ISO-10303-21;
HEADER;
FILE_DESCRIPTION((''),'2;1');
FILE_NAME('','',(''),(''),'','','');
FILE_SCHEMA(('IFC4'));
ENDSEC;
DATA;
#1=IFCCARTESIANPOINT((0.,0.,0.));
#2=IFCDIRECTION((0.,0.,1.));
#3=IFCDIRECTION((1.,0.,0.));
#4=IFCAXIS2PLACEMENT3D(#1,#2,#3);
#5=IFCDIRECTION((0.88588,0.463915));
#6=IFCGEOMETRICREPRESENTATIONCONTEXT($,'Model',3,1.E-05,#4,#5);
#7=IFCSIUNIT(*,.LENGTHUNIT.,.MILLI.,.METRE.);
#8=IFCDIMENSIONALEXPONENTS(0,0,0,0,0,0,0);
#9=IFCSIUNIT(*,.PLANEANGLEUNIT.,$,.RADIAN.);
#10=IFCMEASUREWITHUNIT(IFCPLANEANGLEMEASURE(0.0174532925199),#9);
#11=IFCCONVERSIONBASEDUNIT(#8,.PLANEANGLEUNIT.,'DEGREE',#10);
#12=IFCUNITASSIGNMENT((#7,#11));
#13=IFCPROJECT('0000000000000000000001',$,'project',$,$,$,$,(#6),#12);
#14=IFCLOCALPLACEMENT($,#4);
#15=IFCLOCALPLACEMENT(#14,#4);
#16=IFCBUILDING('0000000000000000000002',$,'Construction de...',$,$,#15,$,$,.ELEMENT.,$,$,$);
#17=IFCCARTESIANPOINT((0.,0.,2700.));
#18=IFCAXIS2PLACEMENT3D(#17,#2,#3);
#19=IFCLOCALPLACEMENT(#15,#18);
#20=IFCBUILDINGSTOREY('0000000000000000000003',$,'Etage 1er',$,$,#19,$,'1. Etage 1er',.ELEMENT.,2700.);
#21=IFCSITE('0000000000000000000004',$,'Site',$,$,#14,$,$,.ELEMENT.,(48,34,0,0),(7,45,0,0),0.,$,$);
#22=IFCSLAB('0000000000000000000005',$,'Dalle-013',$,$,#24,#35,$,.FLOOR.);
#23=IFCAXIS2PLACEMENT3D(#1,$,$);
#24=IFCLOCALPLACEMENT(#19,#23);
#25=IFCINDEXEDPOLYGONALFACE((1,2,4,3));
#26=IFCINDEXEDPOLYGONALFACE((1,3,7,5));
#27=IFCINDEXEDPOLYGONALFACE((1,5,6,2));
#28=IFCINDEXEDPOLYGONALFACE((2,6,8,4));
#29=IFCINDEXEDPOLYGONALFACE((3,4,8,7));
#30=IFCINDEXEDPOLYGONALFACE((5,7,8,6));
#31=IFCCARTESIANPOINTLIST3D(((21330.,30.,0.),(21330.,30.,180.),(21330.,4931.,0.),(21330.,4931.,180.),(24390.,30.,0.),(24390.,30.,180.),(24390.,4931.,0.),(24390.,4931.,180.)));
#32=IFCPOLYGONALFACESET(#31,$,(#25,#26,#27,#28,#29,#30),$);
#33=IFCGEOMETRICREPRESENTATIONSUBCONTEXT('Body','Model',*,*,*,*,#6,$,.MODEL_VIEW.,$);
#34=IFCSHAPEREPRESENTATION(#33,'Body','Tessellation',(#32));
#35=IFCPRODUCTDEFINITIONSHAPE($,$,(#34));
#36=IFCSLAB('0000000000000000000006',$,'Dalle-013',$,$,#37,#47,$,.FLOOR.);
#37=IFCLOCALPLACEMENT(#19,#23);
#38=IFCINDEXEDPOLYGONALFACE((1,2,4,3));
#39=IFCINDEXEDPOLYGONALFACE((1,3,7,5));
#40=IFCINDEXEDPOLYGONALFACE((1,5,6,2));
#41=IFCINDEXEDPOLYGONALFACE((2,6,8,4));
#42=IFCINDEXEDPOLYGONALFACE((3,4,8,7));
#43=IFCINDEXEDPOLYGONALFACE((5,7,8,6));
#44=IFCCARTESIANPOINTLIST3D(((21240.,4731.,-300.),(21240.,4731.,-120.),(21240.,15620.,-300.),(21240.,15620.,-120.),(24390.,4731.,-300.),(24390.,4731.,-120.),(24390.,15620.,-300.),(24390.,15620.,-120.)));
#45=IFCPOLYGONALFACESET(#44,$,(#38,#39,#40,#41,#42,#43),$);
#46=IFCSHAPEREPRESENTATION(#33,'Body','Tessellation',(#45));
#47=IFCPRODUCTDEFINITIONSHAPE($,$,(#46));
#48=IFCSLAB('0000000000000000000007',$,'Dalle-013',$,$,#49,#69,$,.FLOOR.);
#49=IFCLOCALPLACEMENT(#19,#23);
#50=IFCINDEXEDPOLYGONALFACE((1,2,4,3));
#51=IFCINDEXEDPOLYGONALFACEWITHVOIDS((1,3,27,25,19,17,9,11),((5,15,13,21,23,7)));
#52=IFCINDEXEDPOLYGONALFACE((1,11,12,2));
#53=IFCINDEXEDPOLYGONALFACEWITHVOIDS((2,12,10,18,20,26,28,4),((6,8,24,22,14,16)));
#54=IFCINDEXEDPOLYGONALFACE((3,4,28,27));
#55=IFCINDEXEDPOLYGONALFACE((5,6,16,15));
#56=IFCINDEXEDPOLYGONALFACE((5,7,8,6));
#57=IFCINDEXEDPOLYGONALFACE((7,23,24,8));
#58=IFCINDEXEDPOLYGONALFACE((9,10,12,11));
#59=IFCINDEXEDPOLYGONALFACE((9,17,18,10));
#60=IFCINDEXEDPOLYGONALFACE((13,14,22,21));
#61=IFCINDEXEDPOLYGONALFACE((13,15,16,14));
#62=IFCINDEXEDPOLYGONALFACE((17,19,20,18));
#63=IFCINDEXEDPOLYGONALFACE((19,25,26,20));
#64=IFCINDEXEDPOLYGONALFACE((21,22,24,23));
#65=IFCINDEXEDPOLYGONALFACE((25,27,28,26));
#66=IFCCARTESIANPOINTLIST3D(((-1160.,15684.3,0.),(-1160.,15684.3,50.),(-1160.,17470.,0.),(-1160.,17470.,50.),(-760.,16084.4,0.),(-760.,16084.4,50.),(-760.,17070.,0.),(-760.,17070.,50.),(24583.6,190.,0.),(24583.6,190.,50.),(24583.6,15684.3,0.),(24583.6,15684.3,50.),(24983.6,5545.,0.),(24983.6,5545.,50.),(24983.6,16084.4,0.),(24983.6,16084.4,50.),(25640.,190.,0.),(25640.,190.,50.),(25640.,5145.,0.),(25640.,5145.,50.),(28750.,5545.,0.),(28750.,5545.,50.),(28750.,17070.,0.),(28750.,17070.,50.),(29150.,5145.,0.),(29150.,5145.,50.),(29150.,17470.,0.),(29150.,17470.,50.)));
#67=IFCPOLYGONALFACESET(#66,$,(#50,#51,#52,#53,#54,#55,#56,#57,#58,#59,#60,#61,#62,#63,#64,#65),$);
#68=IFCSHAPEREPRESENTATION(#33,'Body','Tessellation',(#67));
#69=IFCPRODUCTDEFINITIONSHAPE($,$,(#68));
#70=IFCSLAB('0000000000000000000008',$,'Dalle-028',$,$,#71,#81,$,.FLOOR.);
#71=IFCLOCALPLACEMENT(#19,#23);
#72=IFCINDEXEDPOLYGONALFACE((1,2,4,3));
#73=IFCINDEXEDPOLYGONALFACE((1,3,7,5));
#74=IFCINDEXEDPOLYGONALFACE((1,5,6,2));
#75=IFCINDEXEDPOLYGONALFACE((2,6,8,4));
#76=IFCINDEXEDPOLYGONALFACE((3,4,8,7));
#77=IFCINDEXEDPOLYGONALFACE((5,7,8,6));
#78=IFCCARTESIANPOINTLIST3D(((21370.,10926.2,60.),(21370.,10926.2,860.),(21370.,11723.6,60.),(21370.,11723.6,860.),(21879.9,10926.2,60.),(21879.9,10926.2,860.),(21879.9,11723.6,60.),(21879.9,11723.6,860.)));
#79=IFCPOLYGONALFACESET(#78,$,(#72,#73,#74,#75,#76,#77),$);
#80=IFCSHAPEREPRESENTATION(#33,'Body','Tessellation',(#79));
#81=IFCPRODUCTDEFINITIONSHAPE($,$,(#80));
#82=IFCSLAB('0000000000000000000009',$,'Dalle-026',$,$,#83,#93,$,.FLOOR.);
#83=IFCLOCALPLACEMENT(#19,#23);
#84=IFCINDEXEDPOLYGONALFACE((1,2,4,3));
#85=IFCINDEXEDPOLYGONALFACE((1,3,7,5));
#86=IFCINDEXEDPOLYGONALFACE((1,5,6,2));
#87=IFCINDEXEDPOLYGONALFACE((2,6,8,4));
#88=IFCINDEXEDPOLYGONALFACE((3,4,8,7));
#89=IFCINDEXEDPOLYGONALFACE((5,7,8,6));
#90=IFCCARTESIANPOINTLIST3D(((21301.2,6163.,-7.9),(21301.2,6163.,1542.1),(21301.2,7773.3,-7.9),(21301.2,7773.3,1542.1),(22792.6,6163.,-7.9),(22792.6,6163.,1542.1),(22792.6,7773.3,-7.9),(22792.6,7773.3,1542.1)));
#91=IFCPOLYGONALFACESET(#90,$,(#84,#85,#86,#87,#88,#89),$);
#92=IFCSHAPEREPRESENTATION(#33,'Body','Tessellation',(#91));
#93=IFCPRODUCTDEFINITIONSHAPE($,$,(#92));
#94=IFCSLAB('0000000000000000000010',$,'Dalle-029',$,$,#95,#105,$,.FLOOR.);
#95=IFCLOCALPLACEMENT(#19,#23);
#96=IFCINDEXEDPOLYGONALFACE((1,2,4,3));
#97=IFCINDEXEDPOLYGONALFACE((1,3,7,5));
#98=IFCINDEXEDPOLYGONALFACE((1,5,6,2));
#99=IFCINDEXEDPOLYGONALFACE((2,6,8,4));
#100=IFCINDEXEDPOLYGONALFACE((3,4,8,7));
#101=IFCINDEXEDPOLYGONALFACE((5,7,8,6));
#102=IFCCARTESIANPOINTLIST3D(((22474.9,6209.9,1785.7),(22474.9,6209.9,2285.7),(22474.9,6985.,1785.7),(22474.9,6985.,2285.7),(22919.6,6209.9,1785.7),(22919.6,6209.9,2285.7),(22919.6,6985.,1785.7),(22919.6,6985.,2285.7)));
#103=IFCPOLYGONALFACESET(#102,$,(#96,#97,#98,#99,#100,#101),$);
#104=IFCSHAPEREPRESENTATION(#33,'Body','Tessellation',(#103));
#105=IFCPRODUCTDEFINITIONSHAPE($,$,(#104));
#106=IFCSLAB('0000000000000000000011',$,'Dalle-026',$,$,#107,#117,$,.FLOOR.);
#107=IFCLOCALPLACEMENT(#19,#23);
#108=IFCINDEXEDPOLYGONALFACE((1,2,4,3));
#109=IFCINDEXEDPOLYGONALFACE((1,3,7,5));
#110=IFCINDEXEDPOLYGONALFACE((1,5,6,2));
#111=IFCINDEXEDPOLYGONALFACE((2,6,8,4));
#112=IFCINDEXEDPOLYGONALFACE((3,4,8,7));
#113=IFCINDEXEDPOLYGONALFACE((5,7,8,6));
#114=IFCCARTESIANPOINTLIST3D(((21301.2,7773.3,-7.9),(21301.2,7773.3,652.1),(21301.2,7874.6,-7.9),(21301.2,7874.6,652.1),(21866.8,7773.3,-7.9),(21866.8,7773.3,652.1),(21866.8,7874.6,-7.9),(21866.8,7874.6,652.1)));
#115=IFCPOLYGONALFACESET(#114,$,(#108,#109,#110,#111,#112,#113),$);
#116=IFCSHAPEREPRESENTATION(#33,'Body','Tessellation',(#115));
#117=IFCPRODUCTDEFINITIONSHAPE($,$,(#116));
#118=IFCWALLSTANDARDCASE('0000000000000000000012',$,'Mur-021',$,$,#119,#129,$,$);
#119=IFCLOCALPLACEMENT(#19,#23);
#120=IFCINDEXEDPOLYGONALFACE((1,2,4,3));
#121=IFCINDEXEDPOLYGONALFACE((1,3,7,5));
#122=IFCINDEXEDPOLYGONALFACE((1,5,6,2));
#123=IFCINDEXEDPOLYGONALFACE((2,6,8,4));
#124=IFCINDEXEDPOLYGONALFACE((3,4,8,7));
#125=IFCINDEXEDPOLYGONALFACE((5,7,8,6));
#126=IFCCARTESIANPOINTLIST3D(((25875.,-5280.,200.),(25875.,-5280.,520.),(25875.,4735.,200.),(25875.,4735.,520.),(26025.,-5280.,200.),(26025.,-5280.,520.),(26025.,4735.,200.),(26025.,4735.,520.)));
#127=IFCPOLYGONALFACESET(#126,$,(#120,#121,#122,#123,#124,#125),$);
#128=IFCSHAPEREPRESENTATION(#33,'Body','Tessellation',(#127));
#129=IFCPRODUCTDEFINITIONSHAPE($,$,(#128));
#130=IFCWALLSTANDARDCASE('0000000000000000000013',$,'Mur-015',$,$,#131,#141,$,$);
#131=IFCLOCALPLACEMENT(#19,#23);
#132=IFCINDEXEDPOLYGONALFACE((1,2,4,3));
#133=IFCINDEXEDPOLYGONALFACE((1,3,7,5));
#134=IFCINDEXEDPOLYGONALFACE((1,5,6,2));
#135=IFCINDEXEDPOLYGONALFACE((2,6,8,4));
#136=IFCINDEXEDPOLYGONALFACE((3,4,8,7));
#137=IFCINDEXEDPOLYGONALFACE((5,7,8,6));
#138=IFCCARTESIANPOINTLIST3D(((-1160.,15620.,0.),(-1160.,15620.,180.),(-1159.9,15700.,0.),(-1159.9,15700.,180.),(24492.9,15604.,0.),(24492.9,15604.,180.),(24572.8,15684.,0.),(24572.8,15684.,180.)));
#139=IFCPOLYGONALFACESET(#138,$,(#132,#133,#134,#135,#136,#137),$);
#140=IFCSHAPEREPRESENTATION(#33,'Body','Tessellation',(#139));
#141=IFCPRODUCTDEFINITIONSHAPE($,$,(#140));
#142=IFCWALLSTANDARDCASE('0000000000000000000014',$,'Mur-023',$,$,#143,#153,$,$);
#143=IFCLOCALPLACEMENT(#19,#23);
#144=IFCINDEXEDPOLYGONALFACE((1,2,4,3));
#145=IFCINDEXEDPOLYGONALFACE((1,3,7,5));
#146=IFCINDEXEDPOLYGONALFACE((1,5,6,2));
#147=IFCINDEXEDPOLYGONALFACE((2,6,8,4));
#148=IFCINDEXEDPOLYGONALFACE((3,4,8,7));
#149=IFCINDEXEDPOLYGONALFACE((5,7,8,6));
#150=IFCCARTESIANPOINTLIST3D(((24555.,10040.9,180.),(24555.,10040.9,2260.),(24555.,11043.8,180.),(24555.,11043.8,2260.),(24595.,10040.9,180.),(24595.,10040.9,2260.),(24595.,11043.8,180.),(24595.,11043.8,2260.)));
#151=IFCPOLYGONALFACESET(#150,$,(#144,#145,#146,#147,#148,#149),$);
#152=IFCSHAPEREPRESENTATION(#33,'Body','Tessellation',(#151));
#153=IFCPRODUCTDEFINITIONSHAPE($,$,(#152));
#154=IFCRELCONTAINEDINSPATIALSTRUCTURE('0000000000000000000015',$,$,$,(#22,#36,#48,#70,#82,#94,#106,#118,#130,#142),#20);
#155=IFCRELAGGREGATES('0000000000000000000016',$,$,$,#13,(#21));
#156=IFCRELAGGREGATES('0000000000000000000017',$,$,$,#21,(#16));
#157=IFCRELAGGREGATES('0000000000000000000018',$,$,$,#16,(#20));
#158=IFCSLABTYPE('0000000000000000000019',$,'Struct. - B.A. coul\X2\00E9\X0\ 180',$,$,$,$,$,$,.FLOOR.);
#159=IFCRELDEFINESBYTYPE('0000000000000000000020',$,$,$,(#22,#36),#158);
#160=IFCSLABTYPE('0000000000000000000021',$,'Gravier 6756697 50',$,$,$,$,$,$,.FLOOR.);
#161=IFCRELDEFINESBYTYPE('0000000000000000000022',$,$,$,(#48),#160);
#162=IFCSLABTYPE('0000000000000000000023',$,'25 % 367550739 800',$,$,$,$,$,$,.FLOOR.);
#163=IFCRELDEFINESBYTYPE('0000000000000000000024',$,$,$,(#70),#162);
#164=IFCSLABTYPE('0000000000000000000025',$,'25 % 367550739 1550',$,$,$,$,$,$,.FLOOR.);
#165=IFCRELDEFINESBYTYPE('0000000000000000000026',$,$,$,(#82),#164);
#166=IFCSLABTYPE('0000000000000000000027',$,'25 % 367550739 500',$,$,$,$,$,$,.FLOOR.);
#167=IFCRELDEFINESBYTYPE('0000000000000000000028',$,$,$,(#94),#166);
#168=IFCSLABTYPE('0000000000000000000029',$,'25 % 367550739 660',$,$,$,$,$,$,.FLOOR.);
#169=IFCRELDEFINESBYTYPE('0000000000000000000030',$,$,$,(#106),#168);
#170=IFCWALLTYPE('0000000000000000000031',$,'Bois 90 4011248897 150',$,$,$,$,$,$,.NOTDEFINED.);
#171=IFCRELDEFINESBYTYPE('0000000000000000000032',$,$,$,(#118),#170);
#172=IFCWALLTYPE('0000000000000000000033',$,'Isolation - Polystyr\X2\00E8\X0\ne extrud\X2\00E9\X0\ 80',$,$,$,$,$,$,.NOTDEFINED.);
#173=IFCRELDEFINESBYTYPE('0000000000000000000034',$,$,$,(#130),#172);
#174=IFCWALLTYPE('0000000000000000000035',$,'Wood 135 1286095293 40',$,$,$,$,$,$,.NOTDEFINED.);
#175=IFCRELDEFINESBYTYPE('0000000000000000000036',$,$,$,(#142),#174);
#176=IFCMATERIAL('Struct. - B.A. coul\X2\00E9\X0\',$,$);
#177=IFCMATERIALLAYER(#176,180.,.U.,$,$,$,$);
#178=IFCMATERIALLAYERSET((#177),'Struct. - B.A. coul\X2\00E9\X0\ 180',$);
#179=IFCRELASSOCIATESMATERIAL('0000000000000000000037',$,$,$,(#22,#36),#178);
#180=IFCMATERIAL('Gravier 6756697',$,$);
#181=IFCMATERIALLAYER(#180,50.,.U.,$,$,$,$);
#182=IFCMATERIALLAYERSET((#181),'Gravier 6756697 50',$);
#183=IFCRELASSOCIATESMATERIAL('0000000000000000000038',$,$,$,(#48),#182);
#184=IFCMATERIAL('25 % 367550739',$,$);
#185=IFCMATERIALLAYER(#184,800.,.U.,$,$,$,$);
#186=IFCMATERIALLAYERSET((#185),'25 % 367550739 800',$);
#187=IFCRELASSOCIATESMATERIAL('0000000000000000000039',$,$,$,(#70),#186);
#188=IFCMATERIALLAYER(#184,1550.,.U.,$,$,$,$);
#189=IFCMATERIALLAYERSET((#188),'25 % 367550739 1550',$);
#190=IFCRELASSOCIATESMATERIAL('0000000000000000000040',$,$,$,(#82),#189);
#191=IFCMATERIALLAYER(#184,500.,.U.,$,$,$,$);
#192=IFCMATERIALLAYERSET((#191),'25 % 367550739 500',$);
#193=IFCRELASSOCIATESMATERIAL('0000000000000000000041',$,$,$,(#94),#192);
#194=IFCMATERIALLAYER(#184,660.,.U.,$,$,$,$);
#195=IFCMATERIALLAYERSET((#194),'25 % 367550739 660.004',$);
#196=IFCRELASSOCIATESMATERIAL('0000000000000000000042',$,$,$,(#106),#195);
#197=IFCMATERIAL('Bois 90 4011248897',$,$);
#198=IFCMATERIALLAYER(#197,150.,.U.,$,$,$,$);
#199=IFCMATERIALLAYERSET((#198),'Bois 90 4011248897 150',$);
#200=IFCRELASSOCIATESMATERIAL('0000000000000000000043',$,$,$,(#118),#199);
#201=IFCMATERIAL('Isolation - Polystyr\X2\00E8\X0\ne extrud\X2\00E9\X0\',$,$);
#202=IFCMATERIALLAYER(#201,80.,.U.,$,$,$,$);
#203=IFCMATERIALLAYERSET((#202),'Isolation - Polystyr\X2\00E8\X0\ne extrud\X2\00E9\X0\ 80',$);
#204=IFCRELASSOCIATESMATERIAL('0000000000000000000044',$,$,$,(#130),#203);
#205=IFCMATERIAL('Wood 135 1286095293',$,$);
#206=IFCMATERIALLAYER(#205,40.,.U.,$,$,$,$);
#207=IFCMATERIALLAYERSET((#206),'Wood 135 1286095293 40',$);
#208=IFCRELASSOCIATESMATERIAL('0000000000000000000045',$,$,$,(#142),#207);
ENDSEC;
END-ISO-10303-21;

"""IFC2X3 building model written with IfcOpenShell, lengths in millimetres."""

from ifc_helpers import new_model, entity, si_unit, converted_unit, direction, frame, origin_with_axes, place, context, subcontext, project, spatial, polyline, outline, extrude, material, layer, layer_set, layer_usage, type_object, element, save


model = new_model("IFC2X3")

# Units and contexts
model_context = context("Model", 3, precision=1e-05, world=origin_with_axes(), true_north=direction((0.88588, 0.463915)))
body_context = subcontext(model_context, "Body", "Model", "MODEL_VIEW")
ifc_project = project(units=[si_unit("LENGTHUNIT", "METRE", prefix="MILLI"), converted_unit("PLANEANGLEUNIT", "DEGREE", entity("IfcPlaneAngleMeasure", 0.0174532925199), si_unit("PLANEANGLEUNIT", "RADIAN"), dimensions=[0, 0, 0, 0, 0, 0, 0])], contexts=[model_context])

# Site, building, storey
site_placement = place(None, origin_with_axes())
site = spatial("IfcSite", under=ifc_project, at=site_placement, Name="Site", CompositionType="ELEMENT", RefLatitude=(48, 34, 0, 0), RefLongitude=(7, 45, 0, 0), RefElevation=0.0)
building_placement = place(site_placement, origin_with_axes())
building = spatial("IfcBuilding", under=site, at=building_placement, Name="Construction de...", CompositionType="ELEMENT")
storey_placement = place(building_placement, frame((0.0, 0.0, 2700.0), z_axis=(0.0, 0.0, 1.0), x_axis=(1.0, 0.0, 0.0)))
storey = spatial("IfcBuildingStorey", under=building, at=storey_placement, Name="Etage 1er", LongName="1. Etage 1er", CompositionType="ELEMENT", Elevation=2700.0)

# Slabs
ifc_material_1 = material(Name="Struct. - B.A. coulé")
ifc_layer_1 = layer(ifc_material_1, 180.0, ventilated="UNKNOWN")
ifc_layer_set_1 = layer_set([ifc_layer_1], Name="Struct. - B.A. coulé 180")
ifc_layer_usage_1 = layer_usage(ifc_layer_set_1, "AXIS3", "NEGATIVE", 180.0)
slab_type_1 = type_object("IfcSlabType", Name="Struct. - B.A. coulé 180", PredefinedType="FLOOR")
slab_1_placement = place(storey_placement, frame((21330.0, 4931.0, 180.0), z_axis=(0.0, 0.0, 1.0), x_axis=(1.0, 0.0, 0.0)))
element("IfcSlab", 1, at=slab_1_placement, inside=storey, type_object=slab_type_1, material=ifc_layer_usage_1, Name="Dalle-013", PredefinedType="FLOOR", context=body_context, shape_type="SweptSolid", body=[
    extrude(outline(polyline([(0.0, 0.0), (0.0, -4901.0), (3060.0, -4901.0), (3060.0, 0.0), (0.0, 0.0)])), frame((0.0, 0.0, -180.0), z_axis=(0.0, 0.0, 1.0), x_axis=(1.0, 0.0, 0.0)), (0.0, 0.0, 1.0), 180.0),
])
ifc_layer_usage_2 = layer_usage(ifc_layer_set_1, "AXIS3", "NEGATIVE", 180.0)
slab_2_placement = place(storey_placement, frame((21240.0, 15620.0, -120.0), z_axis=(0.0, 0.0, 1.0), x_axis=(1.0, 0.0, 0.0)))
element("IfcSlab", 2, at=slab_2_placement, inside=storey, type_object=slab_type_1, material=ifc_layer_usage_2, Name="Dalle-013", PredefinedType="FLOOR", context=body_context, shape_type="SweptSolid", body=[
    extrude(outline(polyline([(0.0, 0.0), (0.0, -10889.0), (3150.0, -10889.0), (3150.0, 0.0), (0.0, 0.0)])), frame((0.0, 0.0, -180.0), z_axis=(0.0, 0.0, 1.0), x_axis=(1.0, 0.0, 0.0)), (0.0, 0.0, 1.0), 180.0),
])

# Slab, opening
ifc_material_2 = material(Name="Gravier 6756697")
ifc_layer_2 = layer(ifc_material_2, 50.0, ventilated="UNKNOWN")
ifc_layer_set_2 = layer_set([ifc_layer_2], Name="Gravier 6756697 50")
ifc_layer_usage_3 = layer_usage(ifc_layer_set_2, "AXIS3", "NEGATIVE", 50.0)
slab_type_2 = type_object("IfcSlabType", Name="Gravier 6756697 50", PredefinedType="FLOOR")
slab_3_placement = place(storey_placement, frame((29150.0, 17470.0, 50.0), z_axis=(0.0, 0.0, 1.0), x_axis=(1.0, 0.0, 0.0)))
slab_3 = element("IfcSlab", 3, at=slab_3_placement, inside=storey, type_object=slab_type_2, material=ifc_layer_usage_3, Name="Dalle-013", PredefinedType="FLOOR", context=body_context, shape_type="SweptSolid", body=[
    extrude(outline(polyline([(0.0, 0.0), (-30310.0, 0.0), (-30310.0, -1785.7), (-4566.4, -1785.7), (-4566.4, -17280.0), (-3510.0, -17280.0), (-3510.0, -12325.0), (0.0, -12325.0), (0.0, 0.0)])), frame((0.0, 0.0, -50.0), z_axis=(0.0, 0.0, 1.0), x_axis=(1.0, 0.0, 0.0)), (0.0, 0.0, 1.0), 50.0),
])
opening_1_placement = place(slab_3_placement, origin_with_axes())
element("IfcOpeningElement", 4, at=opening_1_placement, cuts=slab_3, context=body_context, shape_type="SweptSolid", body=[
    extrude(outline(polyline([(-29910.0, -1385.6), (-4166.4, -1385.6), (-4166.4, -11925.0), (-400.0, -11925.0), (-400.0, -400.0), (-29910.0, -400.0), (-29910.0, -1385.6)])), frame((0.0, 0.0, -50.0), z_axis=(0.0, 0.0, 1.0), x_axis=(1.0, 0.0, 0.0)), (0.0, 0.0, 1.0), 50.0),
])

# Slabs
ifc_material_3 = material(Name="25 % 367550739")
ifc_layer_3 = layer(ifc_material_3, 800.0, ventilated="UNKNOWN")
ifc_layer_set_3 = layer_set([ifc_layer_3], Name="25 % 367550739 800")
ifc_layer_usage_4 = layer_usage(ifc_layer_set_3, "AXIS3", "NEGATIVE", 800.0)
slab_type_3 = type_object("IfcSlabType", Name="25 % 367550739 800", PredefinedType="FLOOR")
slab_4_placement = place(storey_placement, frame((21879.9, 11723.6, 860.0), z_axis=(0.0, 0.0, 1.0), x_axis=(1.0, 0.0, 0.0)))
element("IfcSlab", 5, at=slab_4_placement, inside=storey, type_object=slab_type_3, material=ifc_layer_usage_4, Name="Dalle-028", PredefinedType="FLOOR", context=body_context, shape_type="SweptSolid", body=[
    extrude(outline(polyline([(0.0, 0.0), (-509.9, 0.0), (-509.9, -797.3), (0.0, -797.3), (0.0, 0.0)])), frame((0.0, 0.0, -800.0), z_axis=(0.0, 0.0, 1.0), x_axis=(1.0, 0.0, 0.0)), (0.0, 0.0, 1.0), 800.0),
])
ifc_layer_4 = layer(ifc_material_3, 1550.0, ventilated="UNKNOWN")
ifc_layer_set_4 = layer_set([ifc_layer_4], Name="25 % 367550739 1550")
ifc_layer_usage_5 = layer_usage(ifc_layer_set_4, "AXIS3", "NEGATIVE", 1550.0)
slab_type_4 = type_object("IfcSlabType", Name="25 % 367550739 1550", PredefinedType="FLOOR")
slab_5_placement = place(storey_placement, frame((22792.6, 7773.3, 1542.1), z_axis=(0.0, 0.0, 1.0), x_axis=(1.0, 0.0, 0.0)))
element("IfcSlab", 6, at=slab_5_placement, inside=storey, type_object=slab_type_4, material=ifc_layer_usage_5, Name="Dalle-026", PredefinedType="FLOOR", context=body_context, shape_type="SweptSolid", body=[
    extrude(outline(polyline([(0.0, 0.0), (-1491.3, 0.0), (-1491.3, -1610.3), (0.0, -1610.3), (0.0, 0.0)])), frame((0.0, 0.0, -1550.0), z_axis=(0.0, 0.0, 1.0), x_axis=(1.0, 0.0, 0.0)), (0.0, 0.0, 1.0), 1550.0),
])
ifc_layer_5 = layer(ifc_material_3, 500.0, ventilated="UNKNOWN")
ifc_layer_set_5 = layer_set([ifc_layer_5], Name="25 % 367550739 500")
ifc_layer_usage_6 = layer_usage(ifc_layer_set_5, "AXIS3", "NEGATIVE", 500.0)
slab_type_5 = type_object("IfcSlabType", Name="25 % 367550739 500", PredefinedType="FLOOR")
slab_6_placement = place(storey_placement, frame((22919.6, 6985.0, 2285.7), z_axis=(0.0, 0.0, 1.0), x_axis=(1.0, 0.0, 0.0)))
element("IfcSlab", 7, at=slab_6_placement, inside=storey, type_object=slab_type_5, material=ifc_layer_usage_6, Name="Dalle-029", PredefinedType="FLOOR", context=body_context, shape_type="SweptSolid", body=[
    extrude(outline(polyline([(0.0, 0.0), (-444.7, 0.0), (-444.7, -775.1), (0.0, -775.1), (0.0, 0.0)])), frame((0.0, 0.0, -500.0), z_axis=(0.0, 0.0, 1.0), x_axis=(1.0, 0.0, 0.0)), (0.0, 0.0, 1.0), 500.0),
])
ifc_layer_6 = layer(ifc_material_3, 660.0, ventilated="UNKNOWN")
ifc_layer_set_6 = layer_set([ifc_layer_6], Name="25 % 367550739 660.004")
ifc_layer_usage_7 = layer_usage(ifc_layer_set_6, "AXIS3", "NEGATIVE", 660.0)
slab_type_6 = type_object("IfcSlabType", Name="25 % 367550739 660", PredefinedType="FLOOR")
slab_7_placement = place(storey_placement, frame((21866.8, 7874.6, 652.1), z_axis=(0.0, 0.0, 1.0), x_axis=(1.0, 0.0, 0.0)))
element("IfcSlab", 8, at=slab_7_placement, inside=storey, type_object=slab_type_6, material=ifc_layer_usage_7, Name="Dalle-026", PredefinedType="FLOOR", context=body_context, shape_type="SweptSolid", body=[
    extrude(outline(polyline([(0.0, 0.0), (-565.6, 0.0), (-565.6, -101.3), (0.0, -101.3), (0.0, 0.0)])), frame((0.0, 0.0, -660.0), z_axis=(0.0, 0.0, 1.0), x_axis=(1.0, 0.0, 0.0)), (0.0, 0.0, 1.0), 660.0),
])

# Walls
ifc_material_4 = material(Name="Bois 90 4011248897")
ifc_layer_7 = layer(ifc_material_4, 150.0, ventilated="UNKNOWN")
ifc_layer_set_7 = layer_set([ifc_layer_7], Name="Bois 90 4011248897 150")
ifc_layer_usage_8 = layer_usage(ifc_layer_set_7, "AXIS2", "NEGATIVE", 75.0)
wall_type_1 = type_object("IfcWallType", Name="Bois 90 4011248897 150", PredefinedType="NOTDEFINED")
wall_1_placement = place(storey_placement, frame((25950.0, 4735.0, 200.0), z_axis=(0.0, 0.0, 1.0), x_axis=(0.0, -1.0, 0.0)))
element("IfcWallStandardCase", 9, at=wall_1_placement, inside=storey, type_object=wall_type_1, material=ifc_layer_usage_8, Name="Mur-021", context=body_context, shape_type="SweptSolid", body=[
    extrude(outline(polyline([(0.0, -75.0), (10015.0, -75.0), (10015.0, 75.0), (0.0, 75.0), (0.0, -75.0)])), origin_with_axes(), (0.0, 0.0, 1.0), 320.0),
])
ifc_material_5 = material(Name="Isolation - Polystyrène extrudé")
ifc_layer_8 = layer(ifc_material_5, 80.0, ventilated="UNKNOWN")
ifc_layer_set_8 = layer_set([ifc_layer_8], Name="Isolation - Polystyrène extrudé 80")
ifc_layer_usage_9 = layer_usage(ifc_layer_set_8, "AXIS2", "NEGATIVE", 40.0)
wall_type_2 = type_object("IfcWallType", Name="Isolation - Polystyrène extrudé 80", PredefinedType="NOTDEFINED")
wall_2_placement = place(storey_placement, frame((24532.9, 15644.0, 0.0), z_axis=(0.0, 0.0, 1.0), x_axis=(-1.0, 0.000624, 0.0)))
element("IfcWallStandardCase", 10, at=wall_2_placement, inside=storey, type_object=wall_type_2, material=ifc_layer_usage_9, Name="Mur-015", context=body_context, shape_type="SweptSolid", body=[
    extrude(outline(polyline([(-39.9, -40.0), (25692.8, -40.0), (25692.8, 40.0), (39.9, 40.0), (-39.9, -40.0)])), origin_with_axes(), (0.0, 0.0, 1.0), 180.0),
])
ifc_material_6 = material(Name="Wood 135 1286095293")
ifc_layer_9 = layer(ifc_material_6, 40.0, ventilated="UNKNOWN")
ifc_layer_set_9 = layer_set([ifc_layer_9], Name="Wood 135 1286095293 40")
ifc_layer_usage_10 = layer_usage(ifc_layer_set_9, "AXIS2", "NEGATIVE", 20.0)
wall_type_3 = type_object("IfcWallType", Name="Wood 135 1286095293 40", PredefinedType="NOTDEFINED")
wall_3_placement = place(storey_placement, frame((24575.0, 11043.8, 180.0), z_axis=(0.0, 0.0, 1.0), x_axis=(0.0, -1.0, 0.0)))
element("IfcWallStandardCase", 11, at=wall_3_placement, inside=storey, type_object=wall_type_3, material=ifc_layer_usage_10, Name="Mur-023", context=body_context, shape_type="SweptSolid", body=[
    extrude(outline(polyline([(0.0, -20.0), (1002.8, -20.0), (1002.8, 20.0), (0.0, 20.0), (0.0, -20.0)])), origin_with_axes(), (0.0, 0.0, 1.0), 2080.0),
])

save(model, "model.ifc")
